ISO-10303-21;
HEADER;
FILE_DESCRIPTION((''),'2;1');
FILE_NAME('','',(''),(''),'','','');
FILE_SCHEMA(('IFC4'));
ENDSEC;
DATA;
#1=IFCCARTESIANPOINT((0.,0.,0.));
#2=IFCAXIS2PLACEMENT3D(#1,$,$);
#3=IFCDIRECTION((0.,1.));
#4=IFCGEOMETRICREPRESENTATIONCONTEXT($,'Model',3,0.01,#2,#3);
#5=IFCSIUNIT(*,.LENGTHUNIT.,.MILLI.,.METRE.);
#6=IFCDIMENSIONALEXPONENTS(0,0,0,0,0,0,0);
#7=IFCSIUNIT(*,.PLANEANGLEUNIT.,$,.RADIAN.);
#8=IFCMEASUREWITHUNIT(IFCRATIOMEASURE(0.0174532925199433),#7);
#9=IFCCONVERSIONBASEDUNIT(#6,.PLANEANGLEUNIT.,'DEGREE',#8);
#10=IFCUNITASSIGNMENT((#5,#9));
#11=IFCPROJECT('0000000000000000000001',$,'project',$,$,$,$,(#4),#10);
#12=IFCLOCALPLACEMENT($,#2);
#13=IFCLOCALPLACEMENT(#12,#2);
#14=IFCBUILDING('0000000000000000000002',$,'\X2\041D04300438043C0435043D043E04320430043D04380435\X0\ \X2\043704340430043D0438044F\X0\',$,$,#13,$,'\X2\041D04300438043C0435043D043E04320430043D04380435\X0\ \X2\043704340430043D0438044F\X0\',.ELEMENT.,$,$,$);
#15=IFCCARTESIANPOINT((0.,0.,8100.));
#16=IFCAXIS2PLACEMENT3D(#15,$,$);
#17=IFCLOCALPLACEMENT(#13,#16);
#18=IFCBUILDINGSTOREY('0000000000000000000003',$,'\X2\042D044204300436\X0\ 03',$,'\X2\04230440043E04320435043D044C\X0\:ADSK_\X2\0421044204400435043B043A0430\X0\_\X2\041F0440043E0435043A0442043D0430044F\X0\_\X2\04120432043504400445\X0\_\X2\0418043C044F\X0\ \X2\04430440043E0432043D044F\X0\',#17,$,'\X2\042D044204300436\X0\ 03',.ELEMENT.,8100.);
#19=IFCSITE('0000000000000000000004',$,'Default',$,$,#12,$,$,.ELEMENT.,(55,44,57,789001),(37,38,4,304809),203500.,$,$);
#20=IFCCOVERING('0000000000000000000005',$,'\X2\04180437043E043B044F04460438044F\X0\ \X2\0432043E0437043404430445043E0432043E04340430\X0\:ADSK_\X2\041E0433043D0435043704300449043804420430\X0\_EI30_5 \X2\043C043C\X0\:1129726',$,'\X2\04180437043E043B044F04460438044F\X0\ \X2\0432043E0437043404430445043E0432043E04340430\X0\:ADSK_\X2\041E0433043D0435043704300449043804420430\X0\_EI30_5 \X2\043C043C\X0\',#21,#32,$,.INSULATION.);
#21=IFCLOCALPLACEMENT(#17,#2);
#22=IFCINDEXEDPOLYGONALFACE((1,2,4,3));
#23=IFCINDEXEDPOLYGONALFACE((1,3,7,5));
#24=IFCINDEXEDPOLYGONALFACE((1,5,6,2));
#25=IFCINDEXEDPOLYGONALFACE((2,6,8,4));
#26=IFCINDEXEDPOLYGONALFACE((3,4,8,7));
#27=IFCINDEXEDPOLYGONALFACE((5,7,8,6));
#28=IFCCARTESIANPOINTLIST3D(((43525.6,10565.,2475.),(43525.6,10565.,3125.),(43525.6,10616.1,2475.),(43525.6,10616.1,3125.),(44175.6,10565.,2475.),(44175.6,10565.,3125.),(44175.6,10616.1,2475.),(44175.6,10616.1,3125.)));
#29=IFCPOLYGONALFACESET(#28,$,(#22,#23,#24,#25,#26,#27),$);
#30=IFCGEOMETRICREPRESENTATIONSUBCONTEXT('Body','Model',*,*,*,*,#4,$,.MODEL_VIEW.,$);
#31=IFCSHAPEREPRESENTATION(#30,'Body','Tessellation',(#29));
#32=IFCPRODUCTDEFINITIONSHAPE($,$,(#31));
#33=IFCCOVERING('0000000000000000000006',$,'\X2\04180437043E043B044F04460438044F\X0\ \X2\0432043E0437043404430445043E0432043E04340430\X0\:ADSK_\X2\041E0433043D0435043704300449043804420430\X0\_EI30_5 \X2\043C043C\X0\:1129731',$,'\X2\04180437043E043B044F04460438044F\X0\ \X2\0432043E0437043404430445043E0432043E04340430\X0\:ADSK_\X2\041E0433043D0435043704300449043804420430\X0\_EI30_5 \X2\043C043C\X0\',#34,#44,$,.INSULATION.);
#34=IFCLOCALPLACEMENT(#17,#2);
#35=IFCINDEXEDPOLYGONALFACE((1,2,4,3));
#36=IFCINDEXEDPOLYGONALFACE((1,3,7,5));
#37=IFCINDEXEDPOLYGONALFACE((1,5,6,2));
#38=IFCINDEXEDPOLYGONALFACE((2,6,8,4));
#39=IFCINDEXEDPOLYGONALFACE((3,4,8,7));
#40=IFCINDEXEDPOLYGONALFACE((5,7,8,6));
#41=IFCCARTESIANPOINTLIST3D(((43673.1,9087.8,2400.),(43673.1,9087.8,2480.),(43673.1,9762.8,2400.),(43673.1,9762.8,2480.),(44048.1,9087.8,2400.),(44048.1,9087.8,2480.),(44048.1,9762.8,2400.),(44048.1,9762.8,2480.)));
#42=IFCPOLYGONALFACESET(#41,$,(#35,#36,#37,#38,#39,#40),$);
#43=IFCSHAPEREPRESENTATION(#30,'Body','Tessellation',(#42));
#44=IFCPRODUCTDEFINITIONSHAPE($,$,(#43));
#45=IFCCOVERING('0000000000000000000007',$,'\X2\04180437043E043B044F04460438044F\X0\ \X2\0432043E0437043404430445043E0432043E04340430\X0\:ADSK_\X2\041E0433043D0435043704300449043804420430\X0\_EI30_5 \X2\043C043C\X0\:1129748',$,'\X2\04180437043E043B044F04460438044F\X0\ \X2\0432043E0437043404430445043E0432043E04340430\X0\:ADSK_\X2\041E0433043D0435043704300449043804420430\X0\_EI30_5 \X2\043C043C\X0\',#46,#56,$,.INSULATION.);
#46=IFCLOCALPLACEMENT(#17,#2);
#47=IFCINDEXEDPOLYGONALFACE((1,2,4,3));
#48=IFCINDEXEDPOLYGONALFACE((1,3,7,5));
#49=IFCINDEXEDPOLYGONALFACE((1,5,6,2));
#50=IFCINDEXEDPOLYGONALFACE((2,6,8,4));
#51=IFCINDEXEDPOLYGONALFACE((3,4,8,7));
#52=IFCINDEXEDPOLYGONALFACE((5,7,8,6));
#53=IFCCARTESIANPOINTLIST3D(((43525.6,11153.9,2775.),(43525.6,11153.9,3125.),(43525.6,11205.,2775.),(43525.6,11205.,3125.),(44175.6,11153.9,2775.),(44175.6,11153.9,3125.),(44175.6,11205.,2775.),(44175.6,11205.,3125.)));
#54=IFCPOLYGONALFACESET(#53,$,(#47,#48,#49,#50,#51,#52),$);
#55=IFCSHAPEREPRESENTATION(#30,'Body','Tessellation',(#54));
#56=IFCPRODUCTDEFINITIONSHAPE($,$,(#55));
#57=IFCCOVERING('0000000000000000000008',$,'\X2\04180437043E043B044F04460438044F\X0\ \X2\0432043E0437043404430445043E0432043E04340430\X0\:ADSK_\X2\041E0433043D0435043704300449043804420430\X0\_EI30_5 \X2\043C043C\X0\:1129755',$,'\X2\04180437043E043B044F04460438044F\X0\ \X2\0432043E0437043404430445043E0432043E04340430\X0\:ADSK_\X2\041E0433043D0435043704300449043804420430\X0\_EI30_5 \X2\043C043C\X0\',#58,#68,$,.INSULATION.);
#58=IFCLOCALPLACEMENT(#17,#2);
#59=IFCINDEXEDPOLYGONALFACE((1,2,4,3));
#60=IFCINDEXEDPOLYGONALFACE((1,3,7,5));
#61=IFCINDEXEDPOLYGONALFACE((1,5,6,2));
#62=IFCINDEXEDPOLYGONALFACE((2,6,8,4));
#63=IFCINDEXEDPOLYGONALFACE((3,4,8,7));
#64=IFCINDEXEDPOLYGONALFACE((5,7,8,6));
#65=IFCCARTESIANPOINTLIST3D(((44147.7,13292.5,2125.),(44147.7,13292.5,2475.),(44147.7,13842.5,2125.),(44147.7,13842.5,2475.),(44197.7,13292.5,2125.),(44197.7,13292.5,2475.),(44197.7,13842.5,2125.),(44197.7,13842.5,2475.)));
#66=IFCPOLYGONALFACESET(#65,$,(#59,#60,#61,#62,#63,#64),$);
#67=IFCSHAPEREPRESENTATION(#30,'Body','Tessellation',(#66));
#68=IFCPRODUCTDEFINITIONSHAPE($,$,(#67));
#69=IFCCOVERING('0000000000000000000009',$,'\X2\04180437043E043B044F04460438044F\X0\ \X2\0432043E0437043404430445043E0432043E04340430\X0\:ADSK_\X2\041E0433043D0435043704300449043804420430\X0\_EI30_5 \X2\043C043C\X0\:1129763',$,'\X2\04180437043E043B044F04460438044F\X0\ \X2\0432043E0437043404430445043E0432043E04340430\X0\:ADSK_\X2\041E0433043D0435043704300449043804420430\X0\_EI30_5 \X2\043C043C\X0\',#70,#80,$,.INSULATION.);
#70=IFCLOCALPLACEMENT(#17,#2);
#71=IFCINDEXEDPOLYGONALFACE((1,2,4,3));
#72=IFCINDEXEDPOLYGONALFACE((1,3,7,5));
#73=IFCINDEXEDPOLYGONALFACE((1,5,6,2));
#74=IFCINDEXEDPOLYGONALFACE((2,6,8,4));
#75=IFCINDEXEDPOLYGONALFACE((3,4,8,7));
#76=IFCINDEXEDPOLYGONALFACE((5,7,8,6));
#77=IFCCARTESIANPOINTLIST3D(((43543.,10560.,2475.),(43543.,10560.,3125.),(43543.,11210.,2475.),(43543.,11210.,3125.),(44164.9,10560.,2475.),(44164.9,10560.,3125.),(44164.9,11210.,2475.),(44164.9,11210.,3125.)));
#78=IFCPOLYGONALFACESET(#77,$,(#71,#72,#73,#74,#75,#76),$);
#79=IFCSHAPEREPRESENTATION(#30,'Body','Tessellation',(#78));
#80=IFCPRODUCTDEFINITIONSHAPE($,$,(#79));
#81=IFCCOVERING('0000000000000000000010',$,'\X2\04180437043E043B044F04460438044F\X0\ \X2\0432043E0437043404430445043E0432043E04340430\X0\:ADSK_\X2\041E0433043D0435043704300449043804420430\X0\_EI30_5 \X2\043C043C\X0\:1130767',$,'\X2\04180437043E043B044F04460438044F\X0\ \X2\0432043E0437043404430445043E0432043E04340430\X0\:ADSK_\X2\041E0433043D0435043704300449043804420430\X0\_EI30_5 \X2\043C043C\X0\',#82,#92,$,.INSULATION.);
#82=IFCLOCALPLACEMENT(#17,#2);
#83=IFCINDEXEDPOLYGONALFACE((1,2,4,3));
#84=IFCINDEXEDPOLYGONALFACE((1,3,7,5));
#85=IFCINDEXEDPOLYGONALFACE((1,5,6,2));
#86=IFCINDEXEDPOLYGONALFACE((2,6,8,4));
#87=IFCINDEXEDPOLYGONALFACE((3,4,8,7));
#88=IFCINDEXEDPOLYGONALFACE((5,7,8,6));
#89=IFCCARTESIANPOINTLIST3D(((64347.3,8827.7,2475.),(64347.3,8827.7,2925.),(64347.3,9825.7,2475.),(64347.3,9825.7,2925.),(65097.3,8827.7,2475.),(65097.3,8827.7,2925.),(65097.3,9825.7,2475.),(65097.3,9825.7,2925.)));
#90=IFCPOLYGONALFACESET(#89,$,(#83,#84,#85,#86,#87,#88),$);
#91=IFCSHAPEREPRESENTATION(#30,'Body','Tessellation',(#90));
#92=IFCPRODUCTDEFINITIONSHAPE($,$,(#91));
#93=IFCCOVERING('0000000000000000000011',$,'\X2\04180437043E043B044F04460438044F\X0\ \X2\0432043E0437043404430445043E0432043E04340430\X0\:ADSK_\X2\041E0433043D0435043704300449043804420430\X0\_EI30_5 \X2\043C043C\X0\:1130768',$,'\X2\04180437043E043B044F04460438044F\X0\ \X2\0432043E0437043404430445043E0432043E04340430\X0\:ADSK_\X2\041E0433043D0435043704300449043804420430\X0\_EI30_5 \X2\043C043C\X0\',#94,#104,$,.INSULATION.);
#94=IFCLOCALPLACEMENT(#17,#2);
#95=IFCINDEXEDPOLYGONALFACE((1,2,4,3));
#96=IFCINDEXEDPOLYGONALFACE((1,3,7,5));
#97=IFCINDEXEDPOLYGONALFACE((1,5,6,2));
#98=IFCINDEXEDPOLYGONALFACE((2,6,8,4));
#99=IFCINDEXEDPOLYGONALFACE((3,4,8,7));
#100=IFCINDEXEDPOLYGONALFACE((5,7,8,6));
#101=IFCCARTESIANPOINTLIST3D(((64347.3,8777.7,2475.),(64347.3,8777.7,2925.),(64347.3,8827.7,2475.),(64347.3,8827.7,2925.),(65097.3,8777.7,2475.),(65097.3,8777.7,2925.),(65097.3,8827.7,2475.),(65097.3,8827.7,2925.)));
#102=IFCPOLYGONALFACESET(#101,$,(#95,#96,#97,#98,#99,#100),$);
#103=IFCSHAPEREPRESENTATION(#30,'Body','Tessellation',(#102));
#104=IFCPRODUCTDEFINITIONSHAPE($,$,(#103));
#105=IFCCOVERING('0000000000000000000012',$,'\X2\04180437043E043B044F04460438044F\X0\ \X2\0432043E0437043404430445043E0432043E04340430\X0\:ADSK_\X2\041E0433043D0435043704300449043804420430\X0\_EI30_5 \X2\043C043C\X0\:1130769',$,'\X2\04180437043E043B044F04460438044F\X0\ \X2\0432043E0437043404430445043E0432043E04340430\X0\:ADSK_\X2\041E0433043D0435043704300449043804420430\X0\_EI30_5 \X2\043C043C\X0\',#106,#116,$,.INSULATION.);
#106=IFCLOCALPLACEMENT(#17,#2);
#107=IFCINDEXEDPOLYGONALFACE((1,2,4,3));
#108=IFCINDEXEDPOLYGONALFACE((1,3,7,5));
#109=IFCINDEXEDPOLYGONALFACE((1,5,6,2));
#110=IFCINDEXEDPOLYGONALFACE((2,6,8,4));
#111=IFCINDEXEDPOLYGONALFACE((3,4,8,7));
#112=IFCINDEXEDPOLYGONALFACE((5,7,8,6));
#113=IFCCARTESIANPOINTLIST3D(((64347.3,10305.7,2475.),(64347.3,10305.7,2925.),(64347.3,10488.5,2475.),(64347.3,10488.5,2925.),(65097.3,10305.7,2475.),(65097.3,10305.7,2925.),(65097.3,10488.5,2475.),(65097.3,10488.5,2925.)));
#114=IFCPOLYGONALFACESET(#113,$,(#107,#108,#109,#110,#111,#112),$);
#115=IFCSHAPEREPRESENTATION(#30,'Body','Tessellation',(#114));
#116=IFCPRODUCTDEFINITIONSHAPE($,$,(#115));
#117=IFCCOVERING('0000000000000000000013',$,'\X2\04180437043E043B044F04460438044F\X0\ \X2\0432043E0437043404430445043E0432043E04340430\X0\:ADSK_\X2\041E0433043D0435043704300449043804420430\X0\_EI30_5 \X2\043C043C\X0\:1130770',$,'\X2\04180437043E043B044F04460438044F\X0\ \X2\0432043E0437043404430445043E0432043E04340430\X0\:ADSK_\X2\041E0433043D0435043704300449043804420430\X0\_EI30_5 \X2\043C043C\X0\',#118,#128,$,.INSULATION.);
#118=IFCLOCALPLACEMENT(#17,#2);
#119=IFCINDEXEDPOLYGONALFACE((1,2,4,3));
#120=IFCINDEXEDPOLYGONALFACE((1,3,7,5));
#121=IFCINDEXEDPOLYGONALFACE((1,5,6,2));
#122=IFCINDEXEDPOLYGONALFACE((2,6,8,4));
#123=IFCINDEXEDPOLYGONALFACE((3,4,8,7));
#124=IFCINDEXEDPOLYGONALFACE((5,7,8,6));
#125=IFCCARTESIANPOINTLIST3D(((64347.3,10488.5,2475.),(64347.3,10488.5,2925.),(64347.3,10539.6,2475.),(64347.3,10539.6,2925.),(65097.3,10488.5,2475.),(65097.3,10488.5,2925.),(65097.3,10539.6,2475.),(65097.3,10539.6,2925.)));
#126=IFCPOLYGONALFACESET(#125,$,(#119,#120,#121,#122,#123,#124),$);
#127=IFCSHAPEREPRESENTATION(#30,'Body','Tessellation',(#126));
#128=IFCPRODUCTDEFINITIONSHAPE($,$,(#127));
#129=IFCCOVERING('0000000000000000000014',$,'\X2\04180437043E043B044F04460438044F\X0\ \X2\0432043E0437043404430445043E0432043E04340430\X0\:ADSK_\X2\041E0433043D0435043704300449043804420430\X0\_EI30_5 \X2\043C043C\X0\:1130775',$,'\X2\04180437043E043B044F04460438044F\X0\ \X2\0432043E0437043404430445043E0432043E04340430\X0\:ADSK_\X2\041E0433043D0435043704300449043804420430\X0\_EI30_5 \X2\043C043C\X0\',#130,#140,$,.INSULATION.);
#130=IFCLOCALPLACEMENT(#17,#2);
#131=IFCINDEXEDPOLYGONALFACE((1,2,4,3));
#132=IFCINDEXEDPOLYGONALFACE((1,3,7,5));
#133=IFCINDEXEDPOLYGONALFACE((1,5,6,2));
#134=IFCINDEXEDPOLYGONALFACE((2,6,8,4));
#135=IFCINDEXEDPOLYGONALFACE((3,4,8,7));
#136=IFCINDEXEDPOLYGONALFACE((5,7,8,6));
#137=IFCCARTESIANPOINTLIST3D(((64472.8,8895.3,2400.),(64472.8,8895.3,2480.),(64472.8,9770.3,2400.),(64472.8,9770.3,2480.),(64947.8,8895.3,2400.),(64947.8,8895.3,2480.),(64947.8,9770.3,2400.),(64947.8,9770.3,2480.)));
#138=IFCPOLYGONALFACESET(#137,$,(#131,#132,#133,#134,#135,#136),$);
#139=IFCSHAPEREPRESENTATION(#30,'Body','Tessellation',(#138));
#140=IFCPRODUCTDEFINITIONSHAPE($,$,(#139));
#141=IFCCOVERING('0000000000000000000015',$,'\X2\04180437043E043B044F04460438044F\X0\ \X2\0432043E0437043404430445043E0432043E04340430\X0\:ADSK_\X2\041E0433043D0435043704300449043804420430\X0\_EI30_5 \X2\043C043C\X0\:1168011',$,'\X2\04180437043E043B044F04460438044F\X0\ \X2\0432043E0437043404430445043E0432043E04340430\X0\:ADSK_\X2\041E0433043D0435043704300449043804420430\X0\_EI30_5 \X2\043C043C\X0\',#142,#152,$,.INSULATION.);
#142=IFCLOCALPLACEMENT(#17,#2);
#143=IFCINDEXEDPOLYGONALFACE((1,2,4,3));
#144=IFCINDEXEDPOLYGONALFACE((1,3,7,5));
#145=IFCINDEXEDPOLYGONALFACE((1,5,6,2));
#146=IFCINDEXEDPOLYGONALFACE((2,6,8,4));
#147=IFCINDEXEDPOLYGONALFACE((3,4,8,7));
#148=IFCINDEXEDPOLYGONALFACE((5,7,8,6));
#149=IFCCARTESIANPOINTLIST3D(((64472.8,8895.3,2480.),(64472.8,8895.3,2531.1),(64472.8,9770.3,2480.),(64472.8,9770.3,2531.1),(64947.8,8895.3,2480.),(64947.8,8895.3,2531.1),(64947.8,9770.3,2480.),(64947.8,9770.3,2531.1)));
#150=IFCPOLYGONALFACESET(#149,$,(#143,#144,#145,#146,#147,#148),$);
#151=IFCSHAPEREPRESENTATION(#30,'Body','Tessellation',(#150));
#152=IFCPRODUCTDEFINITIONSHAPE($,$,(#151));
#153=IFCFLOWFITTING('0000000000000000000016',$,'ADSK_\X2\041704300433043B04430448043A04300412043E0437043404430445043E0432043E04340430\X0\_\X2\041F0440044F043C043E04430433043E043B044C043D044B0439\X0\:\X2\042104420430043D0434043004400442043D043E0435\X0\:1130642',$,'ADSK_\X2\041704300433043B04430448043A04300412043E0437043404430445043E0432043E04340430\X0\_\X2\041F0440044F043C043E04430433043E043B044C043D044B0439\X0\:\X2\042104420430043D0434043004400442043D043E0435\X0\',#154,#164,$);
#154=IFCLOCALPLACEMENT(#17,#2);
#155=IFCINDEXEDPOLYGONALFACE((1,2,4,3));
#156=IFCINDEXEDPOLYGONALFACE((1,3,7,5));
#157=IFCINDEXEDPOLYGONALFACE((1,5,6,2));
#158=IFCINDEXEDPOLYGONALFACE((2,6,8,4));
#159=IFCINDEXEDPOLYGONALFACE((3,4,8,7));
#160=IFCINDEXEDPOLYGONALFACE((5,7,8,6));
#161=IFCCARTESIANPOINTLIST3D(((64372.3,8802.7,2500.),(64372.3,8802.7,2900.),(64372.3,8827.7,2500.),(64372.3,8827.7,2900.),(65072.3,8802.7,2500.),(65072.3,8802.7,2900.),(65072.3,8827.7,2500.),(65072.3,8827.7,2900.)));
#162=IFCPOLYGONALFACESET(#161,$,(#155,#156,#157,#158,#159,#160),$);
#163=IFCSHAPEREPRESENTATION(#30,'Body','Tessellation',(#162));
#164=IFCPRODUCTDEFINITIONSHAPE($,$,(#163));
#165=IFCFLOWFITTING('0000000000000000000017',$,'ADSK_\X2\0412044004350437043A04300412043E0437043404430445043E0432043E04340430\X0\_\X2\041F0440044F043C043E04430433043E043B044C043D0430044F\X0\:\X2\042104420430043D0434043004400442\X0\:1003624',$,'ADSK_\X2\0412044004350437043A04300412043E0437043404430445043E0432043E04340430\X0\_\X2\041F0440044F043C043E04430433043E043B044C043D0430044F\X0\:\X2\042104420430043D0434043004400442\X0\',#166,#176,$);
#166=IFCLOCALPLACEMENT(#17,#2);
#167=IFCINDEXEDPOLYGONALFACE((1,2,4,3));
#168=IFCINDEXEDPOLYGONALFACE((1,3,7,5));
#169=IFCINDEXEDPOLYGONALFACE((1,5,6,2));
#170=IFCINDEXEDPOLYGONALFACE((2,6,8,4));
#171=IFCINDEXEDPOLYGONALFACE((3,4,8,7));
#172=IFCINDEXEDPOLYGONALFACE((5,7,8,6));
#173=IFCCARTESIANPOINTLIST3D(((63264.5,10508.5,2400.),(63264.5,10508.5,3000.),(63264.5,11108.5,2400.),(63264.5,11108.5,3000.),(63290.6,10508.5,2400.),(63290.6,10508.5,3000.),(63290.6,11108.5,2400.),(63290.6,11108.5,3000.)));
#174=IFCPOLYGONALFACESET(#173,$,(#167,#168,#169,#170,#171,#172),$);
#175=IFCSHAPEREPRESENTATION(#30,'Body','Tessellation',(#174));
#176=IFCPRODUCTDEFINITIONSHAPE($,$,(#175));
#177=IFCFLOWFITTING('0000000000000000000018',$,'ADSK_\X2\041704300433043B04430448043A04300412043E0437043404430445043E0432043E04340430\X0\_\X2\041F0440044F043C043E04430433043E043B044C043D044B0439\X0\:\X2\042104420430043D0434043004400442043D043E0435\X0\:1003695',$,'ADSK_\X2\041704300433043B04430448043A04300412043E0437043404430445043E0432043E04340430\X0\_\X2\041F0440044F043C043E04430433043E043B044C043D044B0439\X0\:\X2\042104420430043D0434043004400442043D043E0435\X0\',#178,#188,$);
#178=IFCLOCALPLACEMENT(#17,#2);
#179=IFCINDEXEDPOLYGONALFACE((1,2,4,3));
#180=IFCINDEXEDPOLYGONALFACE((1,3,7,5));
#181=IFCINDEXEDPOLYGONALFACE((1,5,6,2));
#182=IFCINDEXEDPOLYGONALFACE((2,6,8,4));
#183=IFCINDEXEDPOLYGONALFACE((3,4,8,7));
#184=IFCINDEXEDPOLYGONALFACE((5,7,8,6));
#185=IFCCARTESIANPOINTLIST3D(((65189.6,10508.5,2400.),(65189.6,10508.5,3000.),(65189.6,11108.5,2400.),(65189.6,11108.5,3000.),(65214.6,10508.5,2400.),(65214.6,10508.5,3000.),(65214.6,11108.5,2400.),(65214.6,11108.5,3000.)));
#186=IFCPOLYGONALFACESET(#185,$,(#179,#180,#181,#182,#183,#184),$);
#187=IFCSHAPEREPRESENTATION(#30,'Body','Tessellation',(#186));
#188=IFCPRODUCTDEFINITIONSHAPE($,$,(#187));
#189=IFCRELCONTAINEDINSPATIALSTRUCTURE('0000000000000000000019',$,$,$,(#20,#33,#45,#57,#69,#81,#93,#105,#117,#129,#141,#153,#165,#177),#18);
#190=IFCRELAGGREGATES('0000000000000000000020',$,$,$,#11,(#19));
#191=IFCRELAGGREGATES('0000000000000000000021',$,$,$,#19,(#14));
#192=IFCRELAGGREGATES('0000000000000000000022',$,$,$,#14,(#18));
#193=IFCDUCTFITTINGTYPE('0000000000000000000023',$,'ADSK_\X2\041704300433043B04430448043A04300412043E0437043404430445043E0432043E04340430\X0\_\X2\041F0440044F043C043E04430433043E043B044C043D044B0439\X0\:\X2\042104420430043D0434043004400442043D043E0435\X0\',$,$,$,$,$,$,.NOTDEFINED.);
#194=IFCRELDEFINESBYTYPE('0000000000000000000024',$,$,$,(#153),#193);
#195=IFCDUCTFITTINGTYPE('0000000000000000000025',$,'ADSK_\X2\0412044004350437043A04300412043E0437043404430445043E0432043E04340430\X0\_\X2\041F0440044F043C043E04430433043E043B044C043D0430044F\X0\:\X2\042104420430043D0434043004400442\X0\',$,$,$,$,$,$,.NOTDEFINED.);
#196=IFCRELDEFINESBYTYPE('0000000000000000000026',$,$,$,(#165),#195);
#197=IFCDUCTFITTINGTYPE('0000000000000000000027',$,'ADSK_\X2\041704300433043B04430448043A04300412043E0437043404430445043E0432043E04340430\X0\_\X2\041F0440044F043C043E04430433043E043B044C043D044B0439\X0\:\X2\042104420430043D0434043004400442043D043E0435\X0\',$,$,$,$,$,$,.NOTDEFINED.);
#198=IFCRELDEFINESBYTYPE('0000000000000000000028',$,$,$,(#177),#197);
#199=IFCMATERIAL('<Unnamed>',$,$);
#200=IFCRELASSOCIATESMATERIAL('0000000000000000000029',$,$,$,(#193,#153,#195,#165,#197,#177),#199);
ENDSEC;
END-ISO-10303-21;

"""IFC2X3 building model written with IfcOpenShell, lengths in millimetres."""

from ifc_helpers import new_model, entity, si_unit, converted_unit, direction, frame, frame_2d, origin, origin_2d_with_axis, place, context, subcontext, project, spatial, rectangle, extrude, source, transform, mapped, material, type_object, type_shapes, element, save


model = new_model("IFC2X3")

# Units and contexts
model_context = context("Model", 3, precision=0.01, world=origin(), true_north=direction((0.0, 1.0)))
body_context = subcontext(model_context, "Body", "Model", "MODEL_VIEW")
ifc_project = project(units=[si_unit("LENGTHUNIT", "METRE", prefix="MILLI"), converted_unit("PLANEANGLEUNIT", "DEGREE", entity("IfcRatioMeasure", 0.0174532925199433), si_unit("PLANEANGLEUNIT", "RADIAN"), dimensions=[0, 0, 0, 0, 0, 0, 0])], contexts=[model_context])

# Site, building, storey
site_placement = place(None, frame((0.0, 0.0, 0.0)))
site = spatial("IfcSite", under=ifc_project, at=site_placement, Name="Default", CompositionType="ELEMENT", RefLatitude=(55, 44, 57, 789001), RefLongitude=(37, 38, 4, 304809), RefElevation=203500.0)
building_placement = place(site_placement, origin())
building = spatial("IfcBuilding", under=site, at=building_placement, Name="Наименование здания", LongName="Наименование здания", CompositionType="ELEMENT")
storey_placement = place(building_placement, frame((0.0, 0.0, 8100.0)))
storey = spatial("IfcBuildingStorey", under=building, at=storey_placement, Name="Этаж 03", ObjectType="Уровень:ADSK_Стрелка_Проектная_Вверх_Имя уровня", LongName="Этаж 03", CompositionType="ELEMENT", Elevation=8100.0)

# Coverings
covering_1_placement = place(storey_placement, frame((43525.6, 10565.0, 2475.0)))
element("IfcCovering", 1, at=covering_1_placement, inside=storey, Name="Изоляция воздуховода:ADSK_Огнезащита_EI30_5 мм:1129726", ObjectType="Изоляция воздуховода:ADSK_Огнезащита_EI30_5 мм", PredefinedType="INSULATION", context=body_context, shape_type="SweptSolid", body=[
    extrude(rectangle(XDim=650.0, YDim=51.1, at=frame_2d((0.0, 0.0), x_axis=(1.0, 0.0))), frame((325.0, 25.5, 0.0)), (0.0, 0.0, 1.0), 650.0),
])
covering_2_placement = place(storey_placement, frame((43673.1, 9087.8, 2400.0)))
element("IfcCovering", 2, at=covering_2_placement, inside=storey, Name="Изоляция воздуховода:ADSK_Огнезащита_EI30_5 мм:1129731", ObjectType="Изоляция воздуховода:ADSK_Огнезащита_EI30_5 мм", PredefinedType="INSULATION", context=body_context, shape_type="SweptSolid", body=[
    extrude(rectangle(XDim=375.0, YDim=675.0, at=origin_2d_with_axis()), frame((187.5, 337.5, 0.0)), (0.0, 0.0, 1.0), 80.0),
])
covering_3_placement = place(storey_placement, frame((43525.6, 11153.9, 2775.0)))
element("IfcCovering", 3, at=covering_3_placement, inside=storey, Name="Изоляция воздуховода:ADSK_Огнезащита_EI30_5 мм:1129748", ObjectType="Изоляция воздуховода:ADSK_Огнезащита_EI30_5 мм", PredefinedType="INSULATION", context=body_context, shape_type="SweptSolid", body=[
    extrude(rectangle(XDim=51.1, YDim=650.0, at=frame_2d((0.0, 0.0), x_axis=(1.0, 0.0))), frame((325.0, 25.5, 0.0), z_axis=(0.0, 0.0, 1.0), x_axis=(0.0, -1.0, 0.0)), (0.0, 0.0, 1.0), 350.0),
])
covering_4_placement = place(storey_placement, frame((44147.7, 13292.5, 2125.0)))
element("IfcCovering", 4, at=covering_4_placement, inside=storey, Name="Изоляция воздуховода:ADSK_Огнезащита_EI30_5 мм:1129755", ObjectType="Изоляция воздуховода:ADSK_Огнезащита_EI30_5 мм", PredefinedType="INSULATION", context=body_context, shape_type="SweptSolid", body=[
    extrude(rectangle(XDim=50.0, YDim=550.0, at=frame_2d((0.0, 0.0), x_axis=(1.0, 0.0))), frame((25.0, 275.0, 0.0), z_axis=(0.0, 0.0, 1.0), x_axis=(-1.0, 0.0, 0.0)), (0.0, 0.0, 1.0), 350.0),
])
covering_5_placement = place(storey_placement, frame((43543.0, 10560.0, 2475.0)))
element("IfcCovering", 5, at=covering_5_placement, inside=storey, Name="Изоляция воздуховода:ADSK_Огнезащита_EI30_5 мм:1129763", ObjectType="Изоляция воздуховода:ADSK_Огнезащита_EI30_5 мм", PredefinedType="INSULATION", context=body_context, shape_type="SweptSolid", body=[
    extrude(rectangle(XDim=621.9, YDim=650.0, at=origin_2d_with_axis()), frame((310.9, 325.0, 0.0)), (0.0, 0.0, 1.0), 650.0),
])
covering_6_placement = place(storey_placement, frame((64347.3, 8827.7, 2475.0)))
element("IfcCovering", 6, at=covering_6_placement, inside=storey, Name="Изоляция воздуховода:ADSK_Огнезащита_EI30_5 мм:1130767", ObjectType="Изоляция воздуховода:ADSK_Огнезащита_EI30_5 мм", PredefinedType="INSULATION", context=body_context, shape_type="SweptSolid", body=[
    extrude(rectangle(XDim=998.0, YDim=750.0, at=frame_2d((0.0, 0.0), x_axis=(1.0, 0.0))), frame((375.0, 499.0, 0.0), z_axis=(0.0, 0.0, 1.0), x_axis=(0.0, -1.0, 0.0)), (0.0, 0.0, 1.0), 450.0),
])
covering_7_placement = place(storey_placement, frame((64347.3, 8777.7, 2475.0)))
element("IfcCovering", 7, at=covering_7_placement, inside=storey, Name="Изоляция воздуховода:ADSK_Огнезащита_EI30_5 мм:1130768", ObjectType="Изоляция воздуховода:ADSK_Огнезащита_EI30_5 мм", PredefinedType="INSULATION", context=body_context, shape_type="SweptSolid", body=[
    extrude(rectangle(XDim=50.0, YDim=750.0, at=origin_2d_with_axis()), frame((375.0, 25.0, 0.0), z_axis=(0.0, 0.0, 1.0), x_axis=(0.0, 1.0, 0.0)), (0.0, 0.0, 1.0), 450.0),
])
covering_8_placement = place(storey_placement, frame((64347.3, 10305.7, 2475.0)))
element("IfcCovering", 8, at=covering_8_placement, inside=storey, Name="Изоляция воздуховода:ADSK_Огнезащита_EI30_5 мм:1130769", ObjectType="Изоляция воздуховода:ADSK_Огнезащита_EI30_5 мм", PredefinedType="INSULATION", context=body_context, shape_type="SweptSolid", body=[
    extrude(rectangle(XDim=182.8, YDim=750.0, at=frame_2d((0.0, 0.0), x_axis=(1.0, 0.0))), frame((375.0, 91.4, 0.0), z_axis=(0.0, 0.0, 1.0), x_axis=(0.0, 1.0, 0.0)), (0.0, 0.0, 1.0), 450.0),
])
covering_9_placement = place(storey_placement, frame((64347.3, 10488.5, 2475.0)))
element("IfcCovering", 9, at=covering_9_placement, inside=storey, Name="Изоляция воздуховода:ADSK_Огнезащита_EI30_5 мм:1130770", ObjectType="Изоляция воздуховода:ADSK_Огнезащита_EI30_5 мм", PredefinedType="INSULATION", context=body_context, shape_type="SweptSolid", body=[
    extrude(rectangle(XDim=750.0, YDim=51.1, at=origin_2d_with_axis()), frame((375.0, 25.5, 0.0)), (0.0, 0.0, 1.0), 450.0),
])
covering_10_placement = place(storey_placement, frame((64472.8, 8895.3, 2400.0)))
element("IfcCovering", 10, at=covering_10_placement, inside=storey, Name="Изоляция воздуховода:ADSK_Огнезащита_EI30_5 мм:1130775", ObjectType="Изоляция воздуховода:ADSK_Огнезащита_EI30_5 мм", PredefinedType="INSULATION", context=body_context, shape_type="SweptSolid", body=[
    extrude(rectangle(XDim=875.0, YDim=475.0, at=frame_2d((0.0, 0.0), x_axis=(1.0, 0.0))), frame((237.5, 437.5, 0.0), z_axis=(0.0, 0.0, 1.0), x_axis=(0.0, -1.0, 0.0)), (0.0, 0.0, 1.0), 80.0),
])
covering_11_placement = place(storey_placement, frame((64472.8, 8895.3, 2480.0)))
element("IfcCovering", 11, at=covering_11_placement, inside=storey, Name="Изоляция воздуховода:ADSK_Огнезащита_EI30_5 мм:1168011", ObjectType="Изоляция воздуховода:ADSK_Огнезащита_EI30_5 мм", PredefinedType="INSULATION", context=body_context, shape_type="SweptSolid", body=[
    extrude(rectangle(XDim=875.0, YDim=475.0, at=frame_2d((0.0, 0.0), x_axis=(1.0, 0.0))), frame((237.5, 437.5, 0.0), z_axis=(0.0, 0.0, 1.0), x_axis=(0.0, -1.0, 0.0)), (0.0, 0.0, 1.0), 51.1),
])

# Flow fittings
ifc_material_1 = material(Name="<Unnamed>")
duct_fitting_type_1 = type_object("IfcDuctFittingType", Name="ADSK_ЗаглушкаВоздуховода_Прямоугольный:Стандартное", PredefinedType="NOTDEFINED", material=ifc_material_1)
shared_shape_1 = source(origin(), body_context, "Body", "SweptSolid", [
    extrude(rectangle(XDim=25.0, YDim=700.0, at=frame_2d((0.0, 0.0), x_axis=(1.0, 0.0))), frame((12.5, 0.0, -200.0)), (0.0, 0.0, 1.0), 400.0),
])
type_shapes(duct_fitting_type_1, [shared_shape_1])
flow_fitting_1_placement = place(storey_placement, frame((64722.3, 8827.7, 2700.0), z_axis=(0.0, 0.0, 1.0), x_axis=(0.0, -1.0, 0.0)))
element("IfcFlowFitting", 12, at=flow_fitting_1_placement, inside=storey, type_object=duct_fitting_type_1, material=ifc_material_1, Name="ADSK_ЗаглушкаВоздуховода_Прямоугольный:Стандартное:1130642", ObjectType="ADSK_ЗаглушкаВоздуховода_Прямоугольный:Стандартное", context=body_context, shape_type="MappedRepresentation", body=[
    mapped(shared_shape_1, transform((0.0, 0.0, 0.0), scale=1.0)),
])
duct_fitting_type_2 = type_object("IfcDuctFittingType", Name="ADSK_ВрезкаВоздуховода_Прямоугольная:Стандарт", PredefinedType="NOTDEFINED", material=ifc_material_1)
shared_shape_2 = source(origin(), body_context, "Body", "SweptSolid", [
    extrude(rectangle(XDim=26.1, YDim=600.0, at=frame_2d((0.0, 0.0), x_axis=(1.0, 0.0))), frame((7.0, 0.0, -300.0)), (0.0, 0.0, 1.0), 600.0),
])
type_shapes(duct_fitting_type_2, [shared_shape_2])
flow_fitting_2_placement = place(storey_placement, frame((63270.6, 10808.5, 2700.0), z_axis=(0.0, -1.0, 0.0), x_axis=(1.0, 0.0, 0.0)))
element("IfcFlowFitting", 13, at=flow_fitting_2_placement, inside=storey, type_object=duct_fitting_type_2, material=ifc_material_1, Name="ADSK_ВрезкаВоздуховода_Прямоугольная:Стандарт:1003624", ObjectType="ADSK_ВрезкаВоздуховода_Прямоугольная:Стандарт", context=body_context, shape_type="MappedRepresentation", body=[
    mapped(shared_shape_2, transform((0.0, 0.0, 0.0), scale=1.0)),
])
duct_fitting_type_3 = type_object("IfcDuctFittingType", Name="ADSK_ЗаглушкаВоздуховода_Прямоугольный:Стандартное", PredefinedType="NOTDEFINED", material=ifc_material_1)
shared_shape_3 = source(origin(), body_context, "Body", "SweptSolid", [
    extrude(rectangle(XDim=25.0, YDim=600.0, at=frame_2d((0.0, 0.0), x_axis=(1.0, 0.0))), frame((12.5, 0.0, -300.0)), (0.0, 0.0, 1.0), 600.0),
])
type_shapes(duct_fitting_type_3, [shared_shape_3])
flow_fitting_3_placement = place(storey_placement, frame((65189.6, 10808.5, 2700.0)))
element("IfcFlowFitting", 14, at=flow_fitting_3_placement, inside=storey, type_object=duct_fitting_type_3, material=ifc_material_1, Name="ADSK_ЗаглушкаВоздуховода_Прямоугольный:Стандартное:1003695", ObjectType="ADSK_ЗаглушкаВоздуховода_Прямоугольный:Стандартное", context=body_context, shape_type="MappedRepresentation", body=[
    mapped(shared_shape_3, transform((0.0, 0.0, 0.0), scale=1.0)),
])

save(model, "model.ifc")
